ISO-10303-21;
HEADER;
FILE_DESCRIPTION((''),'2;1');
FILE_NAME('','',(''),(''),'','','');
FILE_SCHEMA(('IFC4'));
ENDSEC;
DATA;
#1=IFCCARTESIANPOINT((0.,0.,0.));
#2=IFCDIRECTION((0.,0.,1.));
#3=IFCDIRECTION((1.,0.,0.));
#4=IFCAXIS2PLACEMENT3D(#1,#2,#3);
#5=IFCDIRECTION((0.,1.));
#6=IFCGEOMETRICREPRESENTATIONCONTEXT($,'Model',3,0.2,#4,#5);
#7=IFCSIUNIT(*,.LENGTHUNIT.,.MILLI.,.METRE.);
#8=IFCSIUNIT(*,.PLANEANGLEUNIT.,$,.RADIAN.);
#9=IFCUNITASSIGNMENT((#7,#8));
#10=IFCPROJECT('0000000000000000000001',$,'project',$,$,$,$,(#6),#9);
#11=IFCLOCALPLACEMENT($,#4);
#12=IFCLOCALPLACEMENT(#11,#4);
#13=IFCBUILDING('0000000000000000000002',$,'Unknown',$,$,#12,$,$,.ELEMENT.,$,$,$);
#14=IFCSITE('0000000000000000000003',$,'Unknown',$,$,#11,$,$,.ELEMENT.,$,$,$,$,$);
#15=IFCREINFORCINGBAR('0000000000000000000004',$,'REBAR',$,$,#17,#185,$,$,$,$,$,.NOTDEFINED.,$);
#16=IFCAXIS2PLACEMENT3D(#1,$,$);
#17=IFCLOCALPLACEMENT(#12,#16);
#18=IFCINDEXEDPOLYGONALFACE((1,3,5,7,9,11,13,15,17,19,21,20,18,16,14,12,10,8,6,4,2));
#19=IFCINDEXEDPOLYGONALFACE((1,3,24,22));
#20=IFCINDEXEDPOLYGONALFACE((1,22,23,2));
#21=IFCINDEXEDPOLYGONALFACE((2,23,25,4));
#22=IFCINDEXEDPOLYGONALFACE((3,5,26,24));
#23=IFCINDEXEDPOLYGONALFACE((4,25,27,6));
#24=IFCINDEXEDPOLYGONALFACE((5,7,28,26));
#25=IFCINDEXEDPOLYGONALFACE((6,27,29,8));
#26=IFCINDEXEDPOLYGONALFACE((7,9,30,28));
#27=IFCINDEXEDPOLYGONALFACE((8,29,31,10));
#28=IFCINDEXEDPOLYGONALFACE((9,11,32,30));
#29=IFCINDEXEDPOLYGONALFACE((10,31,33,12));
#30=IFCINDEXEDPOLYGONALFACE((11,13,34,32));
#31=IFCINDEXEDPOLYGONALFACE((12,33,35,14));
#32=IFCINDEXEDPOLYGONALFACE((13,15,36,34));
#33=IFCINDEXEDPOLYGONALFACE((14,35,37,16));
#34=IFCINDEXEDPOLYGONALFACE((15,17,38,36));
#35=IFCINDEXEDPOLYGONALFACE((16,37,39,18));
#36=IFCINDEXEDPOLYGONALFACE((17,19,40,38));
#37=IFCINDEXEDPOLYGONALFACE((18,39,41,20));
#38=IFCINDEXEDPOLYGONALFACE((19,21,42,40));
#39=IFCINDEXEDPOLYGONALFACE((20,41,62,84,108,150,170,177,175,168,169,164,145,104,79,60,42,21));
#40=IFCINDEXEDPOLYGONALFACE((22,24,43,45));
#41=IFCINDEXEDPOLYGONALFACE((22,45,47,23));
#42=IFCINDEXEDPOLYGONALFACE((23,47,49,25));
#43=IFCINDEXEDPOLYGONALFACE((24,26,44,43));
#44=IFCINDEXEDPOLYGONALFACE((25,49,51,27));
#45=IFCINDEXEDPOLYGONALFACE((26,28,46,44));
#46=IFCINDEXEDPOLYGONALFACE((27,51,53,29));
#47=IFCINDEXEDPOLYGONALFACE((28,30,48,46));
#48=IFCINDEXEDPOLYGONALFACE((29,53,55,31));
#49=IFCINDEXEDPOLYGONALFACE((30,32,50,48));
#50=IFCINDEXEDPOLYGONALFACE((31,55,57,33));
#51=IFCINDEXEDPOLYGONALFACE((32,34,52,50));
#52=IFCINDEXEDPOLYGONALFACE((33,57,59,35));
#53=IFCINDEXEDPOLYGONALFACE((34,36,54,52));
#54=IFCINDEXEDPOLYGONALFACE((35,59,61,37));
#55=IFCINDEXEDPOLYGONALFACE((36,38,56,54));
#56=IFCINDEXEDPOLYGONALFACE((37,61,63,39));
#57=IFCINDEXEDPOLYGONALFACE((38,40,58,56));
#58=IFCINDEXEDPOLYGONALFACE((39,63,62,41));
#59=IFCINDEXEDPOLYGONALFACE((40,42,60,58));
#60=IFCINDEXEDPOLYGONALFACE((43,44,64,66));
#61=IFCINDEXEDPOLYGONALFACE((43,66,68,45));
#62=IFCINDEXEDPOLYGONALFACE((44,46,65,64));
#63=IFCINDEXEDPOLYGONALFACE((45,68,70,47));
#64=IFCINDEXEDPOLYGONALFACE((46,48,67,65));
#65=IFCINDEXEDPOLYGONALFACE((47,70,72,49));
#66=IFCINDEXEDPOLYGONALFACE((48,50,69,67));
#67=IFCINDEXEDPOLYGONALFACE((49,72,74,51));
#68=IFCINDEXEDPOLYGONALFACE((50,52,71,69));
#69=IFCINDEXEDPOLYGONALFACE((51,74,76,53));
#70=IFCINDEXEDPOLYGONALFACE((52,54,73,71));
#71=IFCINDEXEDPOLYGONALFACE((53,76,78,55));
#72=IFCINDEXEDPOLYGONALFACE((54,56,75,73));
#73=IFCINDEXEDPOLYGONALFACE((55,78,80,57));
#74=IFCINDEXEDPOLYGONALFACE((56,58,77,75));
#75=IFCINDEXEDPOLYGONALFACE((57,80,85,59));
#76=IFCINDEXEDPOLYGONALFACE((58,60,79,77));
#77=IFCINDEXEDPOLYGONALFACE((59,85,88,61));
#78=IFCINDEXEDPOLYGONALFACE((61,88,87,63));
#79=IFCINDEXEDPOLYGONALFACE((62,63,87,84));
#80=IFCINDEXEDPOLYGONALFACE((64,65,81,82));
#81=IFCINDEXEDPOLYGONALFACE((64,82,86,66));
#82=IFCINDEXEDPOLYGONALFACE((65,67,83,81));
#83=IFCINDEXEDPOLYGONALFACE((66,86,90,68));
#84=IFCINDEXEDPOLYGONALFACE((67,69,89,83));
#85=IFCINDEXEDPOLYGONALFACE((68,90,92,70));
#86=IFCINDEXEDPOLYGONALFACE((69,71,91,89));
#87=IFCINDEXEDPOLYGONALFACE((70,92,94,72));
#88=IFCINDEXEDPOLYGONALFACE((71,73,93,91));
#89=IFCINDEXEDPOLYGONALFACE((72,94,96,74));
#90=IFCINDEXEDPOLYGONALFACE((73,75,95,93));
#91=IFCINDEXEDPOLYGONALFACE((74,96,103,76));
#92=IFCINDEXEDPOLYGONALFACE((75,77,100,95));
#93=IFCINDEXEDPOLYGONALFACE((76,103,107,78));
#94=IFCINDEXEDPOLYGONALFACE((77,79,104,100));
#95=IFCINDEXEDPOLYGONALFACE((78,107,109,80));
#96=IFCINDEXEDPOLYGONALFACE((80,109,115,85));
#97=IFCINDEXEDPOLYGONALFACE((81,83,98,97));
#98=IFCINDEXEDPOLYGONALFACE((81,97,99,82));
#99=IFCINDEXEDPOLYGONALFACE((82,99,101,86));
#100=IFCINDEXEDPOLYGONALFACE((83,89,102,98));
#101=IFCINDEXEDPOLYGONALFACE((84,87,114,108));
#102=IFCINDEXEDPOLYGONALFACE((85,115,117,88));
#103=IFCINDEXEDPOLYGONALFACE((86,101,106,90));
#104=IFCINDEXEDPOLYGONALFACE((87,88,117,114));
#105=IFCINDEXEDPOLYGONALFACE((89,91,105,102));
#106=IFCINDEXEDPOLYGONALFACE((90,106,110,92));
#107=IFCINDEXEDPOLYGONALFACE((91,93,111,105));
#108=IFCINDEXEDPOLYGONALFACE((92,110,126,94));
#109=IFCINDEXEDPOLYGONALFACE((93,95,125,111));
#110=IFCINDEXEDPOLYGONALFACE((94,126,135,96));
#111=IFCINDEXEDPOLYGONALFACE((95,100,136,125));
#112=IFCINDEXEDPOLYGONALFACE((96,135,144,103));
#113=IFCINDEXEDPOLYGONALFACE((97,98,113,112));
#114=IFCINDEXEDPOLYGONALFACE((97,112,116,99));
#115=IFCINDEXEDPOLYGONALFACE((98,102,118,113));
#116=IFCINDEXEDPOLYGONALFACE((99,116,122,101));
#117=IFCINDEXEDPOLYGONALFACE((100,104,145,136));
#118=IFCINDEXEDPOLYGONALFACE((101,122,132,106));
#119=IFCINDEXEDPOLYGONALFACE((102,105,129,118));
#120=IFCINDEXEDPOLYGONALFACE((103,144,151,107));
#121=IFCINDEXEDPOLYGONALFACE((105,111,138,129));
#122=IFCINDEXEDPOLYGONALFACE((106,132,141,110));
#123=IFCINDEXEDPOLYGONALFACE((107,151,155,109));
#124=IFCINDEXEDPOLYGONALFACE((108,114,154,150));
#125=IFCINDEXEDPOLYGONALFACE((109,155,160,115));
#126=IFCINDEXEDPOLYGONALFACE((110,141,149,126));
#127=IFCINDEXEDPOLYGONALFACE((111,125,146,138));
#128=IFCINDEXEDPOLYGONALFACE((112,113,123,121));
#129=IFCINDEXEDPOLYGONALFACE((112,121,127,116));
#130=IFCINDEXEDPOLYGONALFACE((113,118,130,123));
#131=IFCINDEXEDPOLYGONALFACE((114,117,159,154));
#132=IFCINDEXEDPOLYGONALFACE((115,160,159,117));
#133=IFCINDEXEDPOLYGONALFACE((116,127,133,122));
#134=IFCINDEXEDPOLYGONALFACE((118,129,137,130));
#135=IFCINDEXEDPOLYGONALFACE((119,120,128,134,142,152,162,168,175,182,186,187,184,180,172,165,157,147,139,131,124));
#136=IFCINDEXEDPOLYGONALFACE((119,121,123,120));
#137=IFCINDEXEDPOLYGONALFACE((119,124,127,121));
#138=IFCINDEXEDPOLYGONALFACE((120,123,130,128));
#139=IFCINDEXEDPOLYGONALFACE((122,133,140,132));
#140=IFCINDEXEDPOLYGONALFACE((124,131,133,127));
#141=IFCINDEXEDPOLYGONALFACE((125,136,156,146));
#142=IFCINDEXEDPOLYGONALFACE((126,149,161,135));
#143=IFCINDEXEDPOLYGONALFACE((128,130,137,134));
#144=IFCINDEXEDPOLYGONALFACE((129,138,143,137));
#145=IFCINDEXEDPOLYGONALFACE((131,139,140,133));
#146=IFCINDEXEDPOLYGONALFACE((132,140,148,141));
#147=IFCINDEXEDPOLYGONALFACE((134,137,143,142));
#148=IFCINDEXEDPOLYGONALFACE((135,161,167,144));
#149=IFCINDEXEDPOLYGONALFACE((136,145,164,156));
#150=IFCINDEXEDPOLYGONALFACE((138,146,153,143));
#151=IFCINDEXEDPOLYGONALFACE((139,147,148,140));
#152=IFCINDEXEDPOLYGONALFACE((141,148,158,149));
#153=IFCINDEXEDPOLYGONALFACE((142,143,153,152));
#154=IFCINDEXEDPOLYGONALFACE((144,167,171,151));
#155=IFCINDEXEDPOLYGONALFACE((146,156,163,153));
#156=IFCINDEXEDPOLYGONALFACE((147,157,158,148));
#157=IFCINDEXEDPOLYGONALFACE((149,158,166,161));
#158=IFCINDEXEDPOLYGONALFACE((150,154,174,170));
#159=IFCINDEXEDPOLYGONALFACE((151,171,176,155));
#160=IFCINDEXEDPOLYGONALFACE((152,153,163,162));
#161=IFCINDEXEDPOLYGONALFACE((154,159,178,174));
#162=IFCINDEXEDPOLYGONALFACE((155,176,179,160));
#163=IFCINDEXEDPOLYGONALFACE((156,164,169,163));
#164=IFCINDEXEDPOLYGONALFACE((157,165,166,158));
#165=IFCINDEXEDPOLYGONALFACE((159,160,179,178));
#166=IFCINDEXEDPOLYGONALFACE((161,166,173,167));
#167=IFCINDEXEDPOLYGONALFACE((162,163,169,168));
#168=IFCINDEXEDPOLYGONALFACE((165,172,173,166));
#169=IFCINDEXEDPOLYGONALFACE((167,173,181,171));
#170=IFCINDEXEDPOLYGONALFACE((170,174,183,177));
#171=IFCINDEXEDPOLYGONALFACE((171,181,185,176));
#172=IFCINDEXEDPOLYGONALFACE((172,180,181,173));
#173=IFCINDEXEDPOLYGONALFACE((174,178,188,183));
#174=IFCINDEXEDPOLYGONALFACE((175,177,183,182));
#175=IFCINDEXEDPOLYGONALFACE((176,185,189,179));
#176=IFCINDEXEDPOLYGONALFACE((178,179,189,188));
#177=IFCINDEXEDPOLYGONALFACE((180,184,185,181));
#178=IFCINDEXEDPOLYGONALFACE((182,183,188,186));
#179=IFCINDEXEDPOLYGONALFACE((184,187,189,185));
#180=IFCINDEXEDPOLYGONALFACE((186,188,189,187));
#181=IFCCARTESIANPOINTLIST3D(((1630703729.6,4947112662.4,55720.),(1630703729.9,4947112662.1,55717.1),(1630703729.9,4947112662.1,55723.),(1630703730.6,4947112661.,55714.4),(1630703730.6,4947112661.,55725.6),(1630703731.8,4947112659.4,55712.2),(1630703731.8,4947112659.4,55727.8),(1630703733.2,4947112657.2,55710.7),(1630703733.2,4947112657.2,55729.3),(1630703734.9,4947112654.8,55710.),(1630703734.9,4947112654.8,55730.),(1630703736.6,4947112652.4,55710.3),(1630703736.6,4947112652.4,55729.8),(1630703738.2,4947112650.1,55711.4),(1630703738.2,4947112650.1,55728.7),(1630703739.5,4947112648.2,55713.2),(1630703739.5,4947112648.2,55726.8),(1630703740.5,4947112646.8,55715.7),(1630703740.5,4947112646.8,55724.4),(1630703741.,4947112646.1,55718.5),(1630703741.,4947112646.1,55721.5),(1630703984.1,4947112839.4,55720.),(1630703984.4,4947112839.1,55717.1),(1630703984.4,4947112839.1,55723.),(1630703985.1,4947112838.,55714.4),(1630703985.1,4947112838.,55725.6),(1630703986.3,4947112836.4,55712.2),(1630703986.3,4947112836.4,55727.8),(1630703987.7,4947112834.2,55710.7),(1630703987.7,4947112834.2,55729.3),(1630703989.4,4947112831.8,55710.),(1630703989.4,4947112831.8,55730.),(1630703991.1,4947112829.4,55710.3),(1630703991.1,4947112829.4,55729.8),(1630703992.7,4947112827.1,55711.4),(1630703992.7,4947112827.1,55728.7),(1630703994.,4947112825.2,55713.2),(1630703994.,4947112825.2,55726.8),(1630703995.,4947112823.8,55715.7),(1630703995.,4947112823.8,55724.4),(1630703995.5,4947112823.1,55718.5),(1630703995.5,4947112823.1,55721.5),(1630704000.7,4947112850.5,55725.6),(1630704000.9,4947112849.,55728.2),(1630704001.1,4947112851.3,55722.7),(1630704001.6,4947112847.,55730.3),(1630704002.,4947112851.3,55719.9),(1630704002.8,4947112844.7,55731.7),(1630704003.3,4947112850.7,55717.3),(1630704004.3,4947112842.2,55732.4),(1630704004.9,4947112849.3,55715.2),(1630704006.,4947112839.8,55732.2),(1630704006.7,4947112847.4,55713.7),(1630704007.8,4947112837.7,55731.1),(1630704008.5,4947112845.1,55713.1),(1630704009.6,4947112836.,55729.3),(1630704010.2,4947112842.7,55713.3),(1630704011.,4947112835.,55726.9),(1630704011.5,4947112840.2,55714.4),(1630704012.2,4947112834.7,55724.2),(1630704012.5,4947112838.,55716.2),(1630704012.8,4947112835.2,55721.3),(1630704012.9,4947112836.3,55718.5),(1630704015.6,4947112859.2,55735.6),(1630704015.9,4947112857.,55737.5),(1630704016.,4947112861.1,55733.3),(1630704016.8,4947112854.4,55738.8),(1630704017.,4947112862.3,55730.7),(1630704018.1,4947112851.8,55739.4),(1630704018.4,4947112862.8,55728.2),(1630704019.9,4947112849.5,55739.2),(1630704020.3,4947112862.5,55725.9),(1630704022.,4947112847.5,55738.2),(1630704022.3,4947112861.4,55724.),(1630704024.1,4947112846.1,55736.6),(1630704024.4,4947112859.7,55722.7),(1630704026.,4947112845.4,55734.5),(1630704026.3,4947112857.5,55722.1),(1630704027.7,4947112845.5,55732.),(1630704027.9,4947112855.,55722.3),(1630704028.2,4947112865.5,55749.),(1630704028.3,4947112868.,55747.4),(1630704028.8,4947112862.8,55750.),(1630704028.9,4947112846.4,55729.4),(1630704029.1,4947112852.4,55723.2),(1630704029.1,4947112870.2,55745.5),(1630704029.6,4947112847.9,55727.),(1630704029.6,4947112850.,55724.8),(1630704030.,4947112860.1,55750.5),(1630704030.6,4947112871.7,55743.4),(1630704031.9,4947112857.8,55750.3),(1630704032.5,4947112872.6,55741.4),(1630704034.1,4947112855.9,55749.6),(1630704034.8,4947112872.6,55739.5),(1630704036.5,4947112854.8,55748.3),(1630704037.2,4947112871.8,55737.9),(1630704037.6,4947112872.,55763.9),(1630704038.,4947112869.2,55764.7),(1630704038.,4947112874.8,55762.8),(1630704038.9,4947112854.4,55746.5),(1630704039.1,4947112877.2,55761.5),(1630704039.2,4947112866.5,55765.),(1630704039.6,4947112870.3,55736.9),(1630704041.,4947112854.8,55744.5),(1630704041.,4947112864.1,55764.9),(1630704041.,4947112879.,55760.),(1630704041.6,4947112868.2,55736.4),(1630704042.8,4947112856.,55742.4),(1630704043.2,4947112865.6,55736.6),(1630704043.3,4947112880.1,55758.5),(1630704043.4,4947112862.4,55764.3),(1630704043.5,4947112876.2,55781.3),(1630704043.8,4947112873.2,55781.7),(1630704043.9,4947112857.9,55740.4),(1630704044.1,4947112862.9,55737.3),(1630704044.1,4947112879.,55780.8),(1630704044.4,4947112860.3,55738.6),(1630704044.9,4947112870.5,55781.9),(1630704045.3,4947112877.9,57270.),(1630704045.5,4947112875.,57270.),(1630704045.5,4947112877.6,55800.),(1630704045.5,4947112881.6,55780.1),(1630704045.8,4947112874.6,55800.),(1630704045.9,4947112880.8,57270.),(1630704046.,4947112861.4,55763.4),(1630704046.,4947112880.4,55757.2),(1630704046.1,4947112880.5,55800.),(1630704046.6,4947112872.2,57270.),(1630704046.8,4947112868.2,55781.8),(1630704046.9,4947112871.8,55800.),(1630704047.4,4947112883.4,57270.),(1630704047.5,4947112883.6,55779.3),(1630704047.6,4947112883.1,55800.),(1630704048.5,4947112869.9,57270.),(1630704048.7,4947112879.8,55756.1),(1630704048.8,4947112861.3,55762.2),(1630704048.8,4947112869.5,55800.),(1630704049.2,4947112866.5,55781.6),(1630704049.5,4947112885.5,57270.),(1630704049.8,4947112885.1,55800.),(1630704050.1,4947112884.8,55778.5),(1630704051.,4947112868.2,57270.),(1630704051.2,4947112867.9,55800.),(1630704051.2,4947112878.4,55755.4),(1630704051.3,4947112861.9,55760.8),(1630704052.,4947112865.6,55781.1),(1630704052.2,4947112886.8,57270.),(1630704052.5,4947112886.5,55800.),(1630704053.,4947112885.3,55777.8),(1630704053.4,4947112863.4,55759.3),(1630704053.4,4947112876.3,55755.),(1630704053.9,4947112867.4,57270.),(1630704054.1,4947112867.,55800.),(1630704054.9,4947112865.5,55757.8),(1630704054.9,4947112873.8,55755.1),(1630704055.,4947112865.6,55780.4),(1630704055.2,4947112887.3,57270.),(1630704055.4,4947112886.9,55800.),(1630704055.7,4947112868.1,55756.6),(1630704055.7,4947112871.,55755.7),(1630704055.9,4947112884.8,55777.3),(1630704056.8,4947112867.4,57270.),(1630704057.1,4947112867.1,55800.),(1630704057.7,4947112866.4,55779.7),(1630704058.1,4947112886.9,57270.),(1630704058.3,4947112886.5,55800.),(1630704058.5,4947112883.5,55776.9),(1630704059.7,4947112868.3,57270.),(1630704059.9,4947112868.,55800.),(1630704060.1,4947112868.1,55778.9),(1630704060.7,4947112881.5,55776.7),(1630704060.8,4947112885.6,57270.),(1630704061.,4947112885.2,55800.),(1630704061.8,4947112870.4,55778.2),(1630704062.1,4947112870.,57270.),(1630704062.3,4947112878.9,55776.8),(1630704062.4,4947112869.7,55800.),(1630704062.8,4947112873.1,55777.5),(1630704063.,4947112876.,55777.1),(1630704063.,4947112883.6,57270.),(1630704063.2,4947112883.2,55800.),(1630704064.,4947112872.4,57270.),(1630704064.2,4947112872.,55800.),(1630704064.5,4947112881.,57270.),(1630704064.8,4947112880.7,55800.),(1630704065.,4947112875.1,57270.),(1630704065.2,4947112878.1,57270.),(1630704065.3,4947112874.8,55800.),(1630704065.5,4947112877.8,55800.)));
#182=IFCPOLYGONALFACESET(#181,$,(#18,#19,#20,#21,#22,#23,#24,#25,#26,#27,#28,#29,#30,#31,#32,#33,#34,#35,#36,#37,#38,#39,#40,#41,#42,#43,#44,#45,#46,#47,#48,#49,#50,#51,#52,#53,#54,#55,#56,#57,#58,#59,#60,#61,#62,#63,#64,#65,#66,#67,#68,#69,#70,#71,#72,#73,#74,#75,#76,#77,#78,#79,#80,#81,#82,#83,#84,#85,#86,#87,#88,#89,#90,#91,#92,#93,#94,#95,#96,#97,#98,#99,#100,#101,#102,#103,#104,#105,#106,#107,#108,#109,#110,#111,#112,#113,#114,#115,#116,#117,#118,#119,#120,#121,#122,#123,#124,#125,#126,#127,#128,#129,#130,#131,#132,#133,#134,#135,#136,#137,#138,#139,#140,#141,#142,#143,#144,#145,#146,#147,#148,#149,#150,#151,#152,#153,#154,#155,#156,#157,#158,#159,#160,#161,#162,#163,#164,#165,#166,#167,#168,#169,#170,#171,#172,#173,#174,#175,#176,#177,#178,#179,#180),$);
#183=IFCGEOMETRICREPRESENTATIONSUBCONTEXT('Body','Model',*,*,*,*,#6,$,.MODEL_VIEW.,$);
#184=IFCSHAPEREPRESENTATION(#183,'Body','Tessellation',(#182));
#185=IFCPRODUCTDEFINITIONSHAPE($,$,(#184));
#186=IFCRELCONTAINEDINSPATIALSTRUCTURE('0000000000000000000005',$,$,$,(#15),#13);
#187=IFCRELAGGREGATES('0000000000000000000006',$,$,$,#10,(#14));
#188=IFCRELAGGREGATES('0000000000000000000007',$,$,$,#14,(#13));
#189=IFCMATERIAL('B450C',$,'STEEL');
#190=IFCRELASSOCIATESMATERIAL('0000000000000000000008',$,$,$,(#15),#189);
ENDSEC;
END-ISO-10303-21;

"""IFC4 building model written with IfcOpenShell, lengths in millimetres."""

from ifc_helpers import new_model, entity, si_unit, direction, frame, origin_with_axes, place, context, subcontext, project, spatial, material, element, save


model = new_model("IFC4")

# Units and contexts
model_context = context("Model", 3, precision=0.2, world=origin_with_axes(), true_north=direction((0.0, 1.0)))
body_context = subcontext(model_context, "Body", "Model", "MODEL_VIEW")
ifc_project = project(units=[si_unit("LENGTHUNIT", "METRE", prefix="MILLI"), si_unit("PLANEANGLEUNIT", "RADIAN")], contexts=[model_context])

# Site, building
site_placement = place(None, origin_with_axes())
site = spatial("IfcSite", under=ifc_project, at=site_placement, Name="Unknown", CompositionType="ELEMENT")
building_placement = place(site_placement, origin_with_axes())
building = spatial("IfcBuilding", under=site, at=building_placement, Name="Unknown", CompositionType="ELEMENT")

# Reinforcing bar
ifc_material = material(Name="B450C", Category="STEEL")
reinforcing_bar_1_placement = place(building_placement, frame((1630704068.0, 4947112946.5, 55670.0), z_axis=(0.570957, -0.82098, 0.0), x_axis=(0.0, 0.0, 1.0)))
element("IfcReinforcingBar", 1, at=reinforcing_bar_1_placement, inside=building, material=ifc_material, Name="REBAR", PredefinedType="NOTDEFINED", context=body_context, shape_type="AdvancedSweptSolid", body=[
    entity("IfcSweptDiskSolid", entity("IfcIndexedPolyCurve", entity("IfcCartesianPointList3D", [[50.0, 440.0, 50.0], [50.0, 130.0, 50.0], [73.4, 73.4, 50.0], [130.0, 50.0, 50.0], [1600.0, 50.0, 49.5]]), [entity("IfcLineIndex", [1, 2]), entity("IfcArcIndex", [2, 3, 4]), entity("IfcLineIndex", [4, 5])]), 10.0),
])

save(model, "model.ifc")
